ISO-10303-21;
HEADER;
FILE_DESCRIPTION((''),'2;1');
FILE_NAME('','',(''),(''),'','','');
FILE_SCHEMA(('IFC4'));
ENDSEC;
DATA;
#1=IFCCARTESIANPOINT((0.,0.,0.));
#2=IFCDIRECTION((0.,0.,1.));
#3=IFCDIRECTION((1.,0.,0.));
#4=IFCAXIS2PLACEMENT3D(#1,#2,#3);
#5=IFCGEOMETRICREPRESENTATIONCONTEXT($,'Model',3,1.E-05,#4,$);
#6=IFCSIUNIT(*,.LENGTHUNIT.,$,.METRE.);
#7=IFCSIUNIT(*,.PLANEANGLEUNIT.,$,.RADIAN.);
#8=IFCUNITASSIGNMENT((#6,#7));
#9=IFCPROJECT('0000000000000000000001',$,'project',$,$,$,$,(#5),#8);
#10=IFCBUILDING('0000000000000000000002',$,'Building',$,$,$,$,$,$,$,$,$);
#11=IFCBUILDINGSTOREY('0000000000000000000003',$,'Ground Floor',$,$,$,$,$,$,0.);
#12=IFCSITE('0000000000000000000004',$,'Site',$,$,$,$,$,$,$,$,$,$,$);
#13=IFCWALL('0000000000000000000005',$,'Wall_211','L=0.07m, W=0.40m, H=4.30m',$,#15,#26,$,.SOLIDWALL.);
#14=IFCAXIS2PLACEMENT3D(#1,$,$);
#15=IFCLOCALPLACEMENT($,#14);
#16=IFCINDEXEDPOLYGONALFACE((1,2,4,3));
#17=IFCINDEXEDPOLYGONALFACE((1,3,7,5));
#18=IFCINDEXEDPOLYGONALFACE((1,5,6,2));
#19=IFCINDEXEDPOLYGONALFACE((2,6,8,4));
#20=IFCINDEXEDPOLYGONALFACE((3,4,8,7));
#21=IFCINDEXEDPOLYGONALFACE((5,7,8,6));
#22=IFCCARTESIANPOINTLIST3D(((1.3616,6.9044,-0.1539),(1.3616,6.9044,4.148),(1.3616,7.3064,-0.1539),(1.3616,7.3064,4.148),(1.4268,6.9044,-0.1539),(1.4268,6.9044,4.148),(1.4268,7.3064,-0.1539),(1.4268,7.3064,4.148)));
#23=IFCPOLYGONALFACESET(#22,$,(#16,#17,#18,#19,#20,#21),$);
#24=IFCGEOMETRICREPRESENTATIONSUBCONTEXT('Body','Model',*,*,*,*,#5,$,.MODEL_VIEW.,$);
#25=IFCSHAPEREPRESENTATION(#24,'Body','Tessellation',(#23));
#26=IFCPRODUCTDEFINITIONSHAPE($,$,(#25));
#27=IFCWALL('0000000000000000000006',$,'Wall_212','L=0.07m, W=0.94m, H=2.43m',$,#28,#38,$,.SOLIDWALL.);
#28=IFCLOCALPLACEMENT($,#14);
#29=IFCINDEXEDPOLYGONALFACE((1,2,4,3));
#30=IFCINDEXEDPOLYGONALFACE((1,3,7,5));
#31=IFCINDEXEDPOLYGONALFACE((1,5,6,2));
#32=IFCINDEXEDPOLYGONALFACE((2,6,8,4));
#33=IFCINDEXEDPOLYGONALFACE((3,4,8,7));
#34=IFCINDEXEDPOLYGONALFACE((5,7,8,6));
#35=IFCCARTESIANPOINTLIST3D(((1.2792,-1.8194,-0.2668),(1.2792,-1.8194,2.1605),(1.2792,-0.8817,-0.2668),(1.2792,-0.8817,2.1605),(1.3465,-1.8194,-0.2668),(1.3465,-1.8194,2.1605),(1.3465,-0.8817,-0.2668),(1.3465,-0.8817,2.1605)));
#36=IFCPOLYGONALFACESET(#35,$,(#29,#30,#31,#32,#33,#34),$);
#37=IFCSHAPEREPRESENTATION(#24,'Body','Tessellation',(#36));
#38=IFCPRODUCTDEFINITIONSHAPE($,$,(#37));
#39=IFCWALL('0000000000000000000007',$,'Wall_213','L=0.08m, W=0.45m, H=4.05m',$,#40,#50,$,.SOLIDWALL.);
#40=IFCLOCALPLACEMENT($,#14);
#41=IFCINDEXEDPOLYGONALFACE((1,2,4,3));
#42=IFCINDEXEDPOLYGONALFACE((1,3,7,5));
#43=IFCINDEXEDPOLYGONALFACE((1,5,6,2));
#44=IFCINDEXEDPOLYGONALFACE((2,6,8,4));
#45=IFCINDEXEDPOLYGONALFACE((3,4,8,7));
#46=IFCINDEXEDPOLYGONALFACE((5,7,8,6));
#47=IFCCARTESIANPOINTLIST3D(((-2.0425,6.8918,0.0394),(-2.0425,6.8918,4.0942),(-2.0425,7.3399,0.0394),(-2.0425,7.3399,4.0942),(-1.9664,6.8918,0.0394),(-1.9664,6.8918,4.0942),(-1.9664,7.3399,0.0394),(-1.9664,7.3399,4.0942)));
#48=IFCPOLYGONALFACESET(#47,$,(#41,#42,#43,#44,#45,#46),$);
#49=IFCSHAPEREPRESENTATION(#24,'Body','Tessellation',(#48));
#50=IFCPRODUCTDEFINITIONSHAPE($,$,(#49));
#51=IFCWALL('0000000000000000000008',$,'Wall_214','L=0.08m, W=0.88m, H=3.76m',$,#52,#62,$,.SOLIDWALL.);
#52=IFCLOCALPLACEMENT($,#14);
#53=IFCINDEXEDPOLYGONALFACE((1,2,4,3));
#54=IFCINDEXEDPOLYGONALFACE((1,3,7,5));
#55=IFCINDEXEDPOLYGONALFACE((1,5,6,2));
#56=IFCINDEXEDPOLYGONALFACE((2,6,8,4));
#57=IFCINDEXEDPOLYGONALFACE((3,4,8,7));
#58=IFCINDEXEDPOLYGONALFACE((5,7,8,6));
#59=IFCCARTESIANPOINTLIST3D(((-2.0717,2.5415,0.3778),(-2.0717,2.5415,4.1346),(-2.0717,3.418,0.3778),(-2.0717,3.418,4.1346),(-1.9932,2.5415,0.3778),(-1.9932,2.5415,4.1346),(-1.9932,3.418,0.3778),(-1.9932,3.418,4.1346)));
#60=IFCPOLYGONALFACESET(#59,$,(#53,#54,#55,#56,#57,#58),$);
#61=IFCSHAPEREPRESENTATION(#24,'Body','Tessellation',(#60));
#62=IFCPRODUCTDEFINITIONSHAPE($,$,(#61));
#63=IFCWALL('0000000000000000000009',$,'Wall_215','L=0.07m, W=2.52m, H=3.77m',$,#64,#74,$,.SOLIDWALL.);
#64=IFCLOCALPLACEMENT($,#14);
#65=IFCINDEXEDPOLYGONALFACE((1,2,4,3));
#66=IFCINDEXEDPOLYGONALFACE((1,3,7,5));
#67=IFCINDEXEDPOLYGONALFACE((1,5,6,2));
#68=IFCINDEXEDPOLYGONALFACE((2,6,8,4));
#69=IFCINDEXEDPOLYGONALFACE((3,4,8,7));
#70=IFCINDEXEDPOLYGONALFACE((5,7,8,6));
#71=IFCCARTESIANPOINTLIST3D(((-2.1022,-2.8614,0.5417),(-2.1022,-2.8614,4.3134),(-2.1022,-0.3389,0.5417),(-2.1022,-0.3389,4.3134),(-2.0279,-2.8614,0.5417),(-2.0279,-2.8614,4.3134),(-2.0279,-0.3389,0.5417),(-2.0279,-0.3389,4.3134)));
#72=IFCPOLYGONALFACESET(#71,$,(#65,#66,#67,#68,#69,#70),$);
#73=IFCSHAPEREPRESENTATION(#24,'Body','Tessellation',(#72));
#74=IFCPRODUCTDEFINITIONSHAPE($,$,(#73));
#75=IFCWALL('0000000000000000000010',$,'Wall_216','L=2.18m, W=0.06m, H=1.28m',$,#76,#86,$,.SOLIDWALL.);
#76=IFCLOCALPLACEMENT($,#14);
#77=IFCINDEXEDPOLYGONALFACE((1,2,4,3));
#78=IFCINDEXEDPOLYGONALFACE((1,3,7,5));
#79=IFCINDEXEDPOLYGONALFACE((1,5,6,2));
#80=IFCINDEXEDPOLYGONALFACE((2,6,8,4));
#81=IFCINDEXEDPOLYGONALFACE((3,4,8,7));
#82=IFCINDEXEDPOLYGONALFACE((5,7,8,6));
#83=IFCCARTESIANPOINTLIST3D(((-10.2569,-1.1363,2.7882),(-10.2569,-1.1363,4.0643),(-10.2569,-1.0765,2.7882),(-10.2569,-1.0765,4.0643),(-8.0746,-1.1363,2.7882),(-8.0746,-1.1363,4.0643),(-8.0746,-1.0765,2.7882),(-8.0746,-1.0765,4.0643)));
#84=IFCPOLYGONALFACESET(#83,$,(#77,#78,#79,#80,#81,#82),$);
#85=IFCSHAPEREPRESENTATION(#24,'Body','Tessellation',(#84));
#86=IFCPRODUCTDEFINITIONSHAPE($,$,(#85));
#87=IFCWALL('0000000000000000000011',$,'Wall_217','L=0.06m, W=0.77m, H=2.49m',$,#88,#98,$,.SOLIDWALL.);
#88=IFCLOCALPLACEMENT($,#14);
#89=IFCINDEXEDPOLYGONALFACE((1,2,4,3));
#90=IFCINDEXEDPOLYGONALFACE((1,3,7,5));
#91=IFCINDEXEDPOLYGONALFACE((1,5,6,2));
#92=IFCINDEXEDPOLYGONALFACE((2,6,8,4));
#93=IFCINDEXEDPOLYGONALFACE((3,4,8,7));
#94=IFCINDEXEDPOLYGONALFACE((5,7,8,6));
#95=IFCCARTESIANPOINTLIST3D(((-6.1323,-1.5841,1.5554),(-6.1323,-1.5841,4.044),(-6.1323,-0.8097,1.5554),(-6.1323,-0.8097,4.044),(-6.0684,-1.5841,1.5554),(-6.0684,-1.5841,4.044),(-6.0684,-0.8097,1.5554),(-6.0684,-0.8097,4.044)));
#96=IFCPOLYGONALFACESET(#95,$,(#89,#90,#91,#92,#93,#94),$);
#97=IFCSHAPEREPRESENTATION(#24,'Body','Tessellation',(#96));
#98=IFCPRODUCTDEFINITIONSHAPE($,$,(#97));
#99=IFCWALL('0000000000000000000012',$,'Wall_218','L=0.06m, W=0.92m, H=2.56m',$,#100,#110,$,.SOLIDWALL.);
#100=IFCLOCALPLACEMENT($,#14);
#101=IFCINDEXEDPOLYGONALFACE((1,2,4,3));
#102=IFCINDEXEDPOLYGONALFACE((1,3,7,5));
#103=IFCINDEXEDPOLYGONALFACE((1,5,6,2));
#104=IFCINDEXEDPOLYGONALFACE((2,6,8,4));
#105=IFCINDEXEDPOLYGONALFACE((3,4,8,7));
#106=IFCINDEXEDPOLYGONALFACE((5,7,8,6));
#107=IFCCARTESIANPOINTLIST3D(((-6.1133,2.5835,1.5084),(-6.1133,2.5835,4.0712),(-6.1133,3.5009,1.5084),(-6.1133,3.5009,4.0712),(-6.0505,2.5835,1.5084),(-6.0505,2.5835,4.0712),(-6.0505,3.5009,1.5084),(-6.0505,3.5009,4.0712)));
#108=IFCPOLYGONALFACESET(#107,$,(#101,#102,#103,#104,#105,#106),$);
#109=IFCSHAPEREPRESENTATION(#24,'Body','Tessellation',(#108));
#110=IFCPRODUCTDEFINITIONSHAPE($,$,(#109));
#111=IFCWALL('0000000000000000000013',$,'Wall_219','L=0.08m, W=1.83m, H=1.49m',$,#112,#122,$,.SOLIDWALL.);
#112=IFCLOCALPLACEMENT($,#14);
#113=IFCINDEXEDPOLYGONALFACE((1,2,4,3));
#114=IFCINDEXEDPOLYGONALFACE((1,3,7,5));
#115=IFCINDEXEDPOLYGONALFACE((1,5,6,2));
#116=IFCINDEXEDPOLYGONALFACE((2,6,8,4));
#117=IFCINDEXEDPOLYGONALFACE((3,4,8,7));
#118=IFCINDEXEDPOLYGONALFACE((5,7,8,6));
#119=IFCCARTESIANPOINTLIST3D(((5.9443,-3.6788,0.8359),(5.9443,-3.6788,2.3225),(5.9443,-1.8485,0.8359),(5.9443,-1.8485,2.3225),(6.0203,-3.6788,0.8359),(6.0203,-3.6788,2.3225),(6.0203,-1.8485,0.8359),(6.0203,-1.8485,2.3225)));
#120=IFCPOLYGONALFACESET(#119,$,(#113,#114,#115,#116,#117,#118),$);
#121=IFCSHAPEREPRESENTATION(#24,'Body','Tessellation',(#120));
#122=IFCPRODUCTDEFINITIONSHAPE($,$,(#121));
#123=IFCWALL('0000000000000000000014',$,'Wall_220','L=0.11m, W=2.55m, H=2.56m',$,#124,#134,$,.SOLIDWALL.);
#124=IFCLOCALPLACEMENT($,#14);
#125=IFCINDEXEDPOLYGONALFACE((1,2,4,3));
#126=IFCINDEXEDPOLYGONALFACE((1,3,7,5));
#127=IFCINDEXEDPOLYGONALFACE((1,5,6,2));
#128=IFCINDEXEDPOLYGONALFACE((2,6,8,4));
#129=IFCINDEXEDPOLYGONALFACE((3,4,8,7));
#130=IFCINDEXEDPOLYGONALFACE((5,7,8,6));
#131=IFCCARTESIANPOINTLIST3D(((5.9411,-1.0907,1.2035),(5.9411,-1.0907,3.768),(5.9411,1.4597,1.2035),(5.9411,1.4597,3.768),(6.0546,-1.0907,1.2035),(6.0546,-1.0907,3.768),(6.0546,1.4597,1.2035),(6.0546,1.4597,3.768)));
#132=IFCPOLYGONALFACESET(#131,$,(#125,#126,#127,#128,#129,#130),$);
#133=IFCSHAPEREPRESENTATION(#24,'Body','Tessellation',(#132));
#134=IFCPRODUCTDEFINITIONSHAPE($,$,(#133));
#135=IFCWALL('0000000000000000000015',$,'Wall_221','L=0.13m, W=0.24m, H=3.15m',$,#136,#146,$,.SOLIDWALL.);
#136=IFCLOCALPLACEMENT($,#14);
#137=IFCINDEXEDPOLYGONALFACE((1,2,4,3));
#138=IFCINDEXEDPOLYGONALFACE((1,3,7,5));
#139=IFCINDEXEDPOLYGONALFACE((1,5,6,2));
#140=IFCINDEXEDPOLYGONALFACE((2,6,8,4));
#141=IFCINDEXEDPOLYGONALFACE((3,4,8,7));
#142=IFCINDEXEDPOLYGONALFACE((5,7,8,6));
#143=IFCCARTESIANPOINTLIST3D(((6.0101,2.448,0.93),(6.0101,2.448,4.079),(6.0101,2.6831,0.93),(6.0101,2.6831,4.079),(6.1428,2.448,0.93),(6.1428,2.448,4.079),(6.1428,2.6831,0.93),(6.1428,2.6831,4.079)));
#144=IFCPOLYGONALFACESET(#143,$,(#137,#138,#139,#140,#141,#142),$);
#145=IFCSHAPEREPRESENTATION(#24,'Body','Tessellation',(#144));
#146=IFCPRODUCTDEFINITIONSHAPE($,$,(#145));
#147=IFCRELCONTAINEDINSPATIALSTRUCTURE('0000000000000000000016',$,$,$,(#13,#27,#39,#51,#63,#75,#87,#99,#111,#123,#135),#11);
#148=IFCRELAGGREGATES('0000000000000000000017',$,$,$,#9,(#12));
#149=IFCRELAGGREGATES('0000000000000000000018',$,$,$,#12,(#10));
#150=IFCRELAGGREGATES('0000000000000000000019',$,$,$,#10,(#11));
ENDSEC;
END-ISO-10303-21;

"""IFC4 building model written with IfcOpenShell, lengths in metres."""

from ifc_helpers import new_model, si_unit, frame, origin_with_axes, origin_2d, context, subcontext, project, spatial, rectangle, extrude, element, save


model = new_model("IFC4")

# Units and contexts
model_context = context("Model", 3, precision=1e-05, world=origin_with_axes())
body_context = subcontext(model_context, "Body", "Model", "MODEL_VIEW")
ifc_project = project(units=[si_unit("LENGTHUNIT", "METRE"), si_unit("PLANEANGLEUNIT", "RADIAN")], contexts=[model_context])

# Site, building, storey
site = spatial("IfcSite", under=ifc_project, Name="Site")
building = spatial("IfcBuilding", under=site, Name="Building")
storey = spatial("IfcBuildingStorey", under=building, Name="Ground Floor", Elevation=0.0)

# Walls
element("IfcWall", 1, inside=storey, Name="Wall_211", Description="L=0.07m, W=0.40m, H=4.30m", PredefinedType="SOLIDWALL", context=body_context, shape_type="SweptSolid", body=[
    extrude(rectangle(XDim=0.0652, YDim=0.402, at=origin_2d()), frame((1.3942, 7.1054, -0.1539), z_axis=(0.0, 0.0, 1.0), x_axis=(1.0, 0.0, 0.0)), (0.0, 0.0, 1.0), 4.3019),
])
element("IfcWall", 2, inside=storey, Name="Wall_212", Description="L=0.07m, W=0.94m, H=2.43m", PredefinedType="SOLIDWALL", context=body_context, shape_type="SweptSolid", body=[
    extrude(rectangle(XDim=0.0673, YDim=0.9377, at=origin_2d()), frame((1.3128, -1.3506, -0.2668), z_axis=(0.0, 0.0, 1.0), x_axis=(1.0, 0.0, 0.0)), (0.0, 0.0, 1.0), 2.4273),
])
element("IfcWall", 3, inside=storey, Name="Wall_213", Description="L=0.08m, W=0.45m, H=4.05m", PredefinedType="SOLIDWALL", context=body_context, shape_type="SweptSolid", body=[
    extrude(rectangle(XDim=0.0761, YDim=0.4481, at=origin_2d()), frame((-2.0045, 7.1159, 0.0394), z_axis=(0.0, 0.0, 1.0), x_axis=(1.0, 0.0, 0.0)), (0.0, 0.0, 1.0), 4.0548),
])
element("IfcWall", 4, inside=storey, Name="Wall_214", Description="L=0.08m, W=0.88m, H=3.76m", PredefinedType="SOLIDWALL", context=body_context, shape_type="SweptSolid", body=[
    extrude(rectangle(XDim=0.0785, YDim=0.8766, at=origin_2d()), frame((-2.0324, 2.9798, 0.3778), z_axis=(0.0, 0.0, 1.0), x_axis=(1.0, 0.0, 0.0)), (0.0, 0.0, 1.0), 3.7568),
])
element("IfcWall", 5, inside=storey, Name="Wall_215", Description="L=0.07m, W=2.52m, H=3.77m", PredefinedType="SOLIDWALL", context=body_context, shape_type="SweptSolid", body=[
    extrude(rectangle(XDim=0.0743, YDim=2.5225, at=origin_2d()), frame((-2.065, -1.6002, 0.5417), z_axis=(0.0, 0.0, 1.0), x_axis=(1.0, 0.0, 0.0)), (0.0, 0.0, 1.0), 3.7718),
])
element("IfcWall", 6, inside=storey, Name="Wall_216", Description="L=2.18m, W=0.06m, H=1.28m", PredefinedType="SOLIDWALL", context=body_context, shape_type="SweptSolid", body=[
    extrude(rectangle(XDim=2.1823, YDim=0.0598, at=origin_2d()), frame((-9.1657, -1.1064, 2.7882), z_axis=(0.0, 0.0, 1.0), x_axis=(1.0, 0.0, 0.0)), (0.0, 0.0, 1.0), 1.2761),
])
element("IfcWall", 7, inside=storey, Name="Wall_217", Description="L=0.06m, W=0.77m, H=2.49m", PredefinedType="SOLIDWALL", context=body_context, shape_type="SweptSolid", body=[
    extrude(rectangle(XDim=0.0639, YDim=0.7743, at=origin_2d()), frame((-6.1003, -1.1969, 1.5554), z_axis=(0.0, 0.0, 1.0), x_axis=(1.0, 0.0, 0.0)), (0.0, 0.0, 1.0), 2.4885),
])
element("IfcWall", 8, inside=storey, Name="Wall_218", Description="L=0.06m, W=0.92m, H=2.56m", PredefinedType="SOLIDWALL", context=body_context, shape_type="SweptSolid", body=[
    extrude(rectangle(XDim=0.0628, YDim=0.9174, at=origin_2d()), frame((-6.0819, 3.0422, 1.5084), z_axis=(0.0, 0.0, 1.0), x_axis=(1.0, 0.0, 0.0)), (0.0, 0.0, 1.0), 2.5628),
])
element("IfcWall", 9, inside=storey, Name="Wall_219", Description="L=0.08m, W=1.83m, H=1.49m", PredefinedType="SOLIDWALL", context=body_context, shape_type="SweptSolid", body=[
    extrude(rectangle(XDim=0.076, YDim=1.8302, at=origin_2d()), frame((5.9823, -2.7636, 0.8359), z_axis=(0.0, 0.0, 1.0), x_axis=(1.0, 0.0, 0.0)), (0.0, 0.0, 1.0), 1.4866),
])
element("IfcWall", 10, inside=storey, Name="Wall_220", Description="L=0.11m, W=2.55m, H=2.56m", PredefinedType="SOLIDWALL", context=body_context, shape_type="SweptSolid", body=[
    extrude(rectangle(XDim=0.1134, YDim=2.5504, at=origin_2d()), frame((5.9978, 0.1845, 1.2035), z_axis=(0.0, 0.0, 1.0), x_axis=(1.0, 0.0, 0.0)), (0.0, 0.0, 1.0), 2.5645),
])
element("IfcWall", 11, inside=storey, Name="Wall_221", Description="L=0.13m, W=0.24m, H=3.15m", PredefinedType="SOLIDWALL", context=body_context, shape_type="SweptSolid", body=[
    extrude(rectangle(XDim=0.1328, YDim=0.2351, at=origin_2d()), frame((6.0764, 2.5656, 0.93), z_axis=(0.0, 0.0, 1.0), x_axis=(1.0, 0.0, 0.0)), (0.0, 0.0, 1.0), 3.149),
])

save(model, "model.ifc")
